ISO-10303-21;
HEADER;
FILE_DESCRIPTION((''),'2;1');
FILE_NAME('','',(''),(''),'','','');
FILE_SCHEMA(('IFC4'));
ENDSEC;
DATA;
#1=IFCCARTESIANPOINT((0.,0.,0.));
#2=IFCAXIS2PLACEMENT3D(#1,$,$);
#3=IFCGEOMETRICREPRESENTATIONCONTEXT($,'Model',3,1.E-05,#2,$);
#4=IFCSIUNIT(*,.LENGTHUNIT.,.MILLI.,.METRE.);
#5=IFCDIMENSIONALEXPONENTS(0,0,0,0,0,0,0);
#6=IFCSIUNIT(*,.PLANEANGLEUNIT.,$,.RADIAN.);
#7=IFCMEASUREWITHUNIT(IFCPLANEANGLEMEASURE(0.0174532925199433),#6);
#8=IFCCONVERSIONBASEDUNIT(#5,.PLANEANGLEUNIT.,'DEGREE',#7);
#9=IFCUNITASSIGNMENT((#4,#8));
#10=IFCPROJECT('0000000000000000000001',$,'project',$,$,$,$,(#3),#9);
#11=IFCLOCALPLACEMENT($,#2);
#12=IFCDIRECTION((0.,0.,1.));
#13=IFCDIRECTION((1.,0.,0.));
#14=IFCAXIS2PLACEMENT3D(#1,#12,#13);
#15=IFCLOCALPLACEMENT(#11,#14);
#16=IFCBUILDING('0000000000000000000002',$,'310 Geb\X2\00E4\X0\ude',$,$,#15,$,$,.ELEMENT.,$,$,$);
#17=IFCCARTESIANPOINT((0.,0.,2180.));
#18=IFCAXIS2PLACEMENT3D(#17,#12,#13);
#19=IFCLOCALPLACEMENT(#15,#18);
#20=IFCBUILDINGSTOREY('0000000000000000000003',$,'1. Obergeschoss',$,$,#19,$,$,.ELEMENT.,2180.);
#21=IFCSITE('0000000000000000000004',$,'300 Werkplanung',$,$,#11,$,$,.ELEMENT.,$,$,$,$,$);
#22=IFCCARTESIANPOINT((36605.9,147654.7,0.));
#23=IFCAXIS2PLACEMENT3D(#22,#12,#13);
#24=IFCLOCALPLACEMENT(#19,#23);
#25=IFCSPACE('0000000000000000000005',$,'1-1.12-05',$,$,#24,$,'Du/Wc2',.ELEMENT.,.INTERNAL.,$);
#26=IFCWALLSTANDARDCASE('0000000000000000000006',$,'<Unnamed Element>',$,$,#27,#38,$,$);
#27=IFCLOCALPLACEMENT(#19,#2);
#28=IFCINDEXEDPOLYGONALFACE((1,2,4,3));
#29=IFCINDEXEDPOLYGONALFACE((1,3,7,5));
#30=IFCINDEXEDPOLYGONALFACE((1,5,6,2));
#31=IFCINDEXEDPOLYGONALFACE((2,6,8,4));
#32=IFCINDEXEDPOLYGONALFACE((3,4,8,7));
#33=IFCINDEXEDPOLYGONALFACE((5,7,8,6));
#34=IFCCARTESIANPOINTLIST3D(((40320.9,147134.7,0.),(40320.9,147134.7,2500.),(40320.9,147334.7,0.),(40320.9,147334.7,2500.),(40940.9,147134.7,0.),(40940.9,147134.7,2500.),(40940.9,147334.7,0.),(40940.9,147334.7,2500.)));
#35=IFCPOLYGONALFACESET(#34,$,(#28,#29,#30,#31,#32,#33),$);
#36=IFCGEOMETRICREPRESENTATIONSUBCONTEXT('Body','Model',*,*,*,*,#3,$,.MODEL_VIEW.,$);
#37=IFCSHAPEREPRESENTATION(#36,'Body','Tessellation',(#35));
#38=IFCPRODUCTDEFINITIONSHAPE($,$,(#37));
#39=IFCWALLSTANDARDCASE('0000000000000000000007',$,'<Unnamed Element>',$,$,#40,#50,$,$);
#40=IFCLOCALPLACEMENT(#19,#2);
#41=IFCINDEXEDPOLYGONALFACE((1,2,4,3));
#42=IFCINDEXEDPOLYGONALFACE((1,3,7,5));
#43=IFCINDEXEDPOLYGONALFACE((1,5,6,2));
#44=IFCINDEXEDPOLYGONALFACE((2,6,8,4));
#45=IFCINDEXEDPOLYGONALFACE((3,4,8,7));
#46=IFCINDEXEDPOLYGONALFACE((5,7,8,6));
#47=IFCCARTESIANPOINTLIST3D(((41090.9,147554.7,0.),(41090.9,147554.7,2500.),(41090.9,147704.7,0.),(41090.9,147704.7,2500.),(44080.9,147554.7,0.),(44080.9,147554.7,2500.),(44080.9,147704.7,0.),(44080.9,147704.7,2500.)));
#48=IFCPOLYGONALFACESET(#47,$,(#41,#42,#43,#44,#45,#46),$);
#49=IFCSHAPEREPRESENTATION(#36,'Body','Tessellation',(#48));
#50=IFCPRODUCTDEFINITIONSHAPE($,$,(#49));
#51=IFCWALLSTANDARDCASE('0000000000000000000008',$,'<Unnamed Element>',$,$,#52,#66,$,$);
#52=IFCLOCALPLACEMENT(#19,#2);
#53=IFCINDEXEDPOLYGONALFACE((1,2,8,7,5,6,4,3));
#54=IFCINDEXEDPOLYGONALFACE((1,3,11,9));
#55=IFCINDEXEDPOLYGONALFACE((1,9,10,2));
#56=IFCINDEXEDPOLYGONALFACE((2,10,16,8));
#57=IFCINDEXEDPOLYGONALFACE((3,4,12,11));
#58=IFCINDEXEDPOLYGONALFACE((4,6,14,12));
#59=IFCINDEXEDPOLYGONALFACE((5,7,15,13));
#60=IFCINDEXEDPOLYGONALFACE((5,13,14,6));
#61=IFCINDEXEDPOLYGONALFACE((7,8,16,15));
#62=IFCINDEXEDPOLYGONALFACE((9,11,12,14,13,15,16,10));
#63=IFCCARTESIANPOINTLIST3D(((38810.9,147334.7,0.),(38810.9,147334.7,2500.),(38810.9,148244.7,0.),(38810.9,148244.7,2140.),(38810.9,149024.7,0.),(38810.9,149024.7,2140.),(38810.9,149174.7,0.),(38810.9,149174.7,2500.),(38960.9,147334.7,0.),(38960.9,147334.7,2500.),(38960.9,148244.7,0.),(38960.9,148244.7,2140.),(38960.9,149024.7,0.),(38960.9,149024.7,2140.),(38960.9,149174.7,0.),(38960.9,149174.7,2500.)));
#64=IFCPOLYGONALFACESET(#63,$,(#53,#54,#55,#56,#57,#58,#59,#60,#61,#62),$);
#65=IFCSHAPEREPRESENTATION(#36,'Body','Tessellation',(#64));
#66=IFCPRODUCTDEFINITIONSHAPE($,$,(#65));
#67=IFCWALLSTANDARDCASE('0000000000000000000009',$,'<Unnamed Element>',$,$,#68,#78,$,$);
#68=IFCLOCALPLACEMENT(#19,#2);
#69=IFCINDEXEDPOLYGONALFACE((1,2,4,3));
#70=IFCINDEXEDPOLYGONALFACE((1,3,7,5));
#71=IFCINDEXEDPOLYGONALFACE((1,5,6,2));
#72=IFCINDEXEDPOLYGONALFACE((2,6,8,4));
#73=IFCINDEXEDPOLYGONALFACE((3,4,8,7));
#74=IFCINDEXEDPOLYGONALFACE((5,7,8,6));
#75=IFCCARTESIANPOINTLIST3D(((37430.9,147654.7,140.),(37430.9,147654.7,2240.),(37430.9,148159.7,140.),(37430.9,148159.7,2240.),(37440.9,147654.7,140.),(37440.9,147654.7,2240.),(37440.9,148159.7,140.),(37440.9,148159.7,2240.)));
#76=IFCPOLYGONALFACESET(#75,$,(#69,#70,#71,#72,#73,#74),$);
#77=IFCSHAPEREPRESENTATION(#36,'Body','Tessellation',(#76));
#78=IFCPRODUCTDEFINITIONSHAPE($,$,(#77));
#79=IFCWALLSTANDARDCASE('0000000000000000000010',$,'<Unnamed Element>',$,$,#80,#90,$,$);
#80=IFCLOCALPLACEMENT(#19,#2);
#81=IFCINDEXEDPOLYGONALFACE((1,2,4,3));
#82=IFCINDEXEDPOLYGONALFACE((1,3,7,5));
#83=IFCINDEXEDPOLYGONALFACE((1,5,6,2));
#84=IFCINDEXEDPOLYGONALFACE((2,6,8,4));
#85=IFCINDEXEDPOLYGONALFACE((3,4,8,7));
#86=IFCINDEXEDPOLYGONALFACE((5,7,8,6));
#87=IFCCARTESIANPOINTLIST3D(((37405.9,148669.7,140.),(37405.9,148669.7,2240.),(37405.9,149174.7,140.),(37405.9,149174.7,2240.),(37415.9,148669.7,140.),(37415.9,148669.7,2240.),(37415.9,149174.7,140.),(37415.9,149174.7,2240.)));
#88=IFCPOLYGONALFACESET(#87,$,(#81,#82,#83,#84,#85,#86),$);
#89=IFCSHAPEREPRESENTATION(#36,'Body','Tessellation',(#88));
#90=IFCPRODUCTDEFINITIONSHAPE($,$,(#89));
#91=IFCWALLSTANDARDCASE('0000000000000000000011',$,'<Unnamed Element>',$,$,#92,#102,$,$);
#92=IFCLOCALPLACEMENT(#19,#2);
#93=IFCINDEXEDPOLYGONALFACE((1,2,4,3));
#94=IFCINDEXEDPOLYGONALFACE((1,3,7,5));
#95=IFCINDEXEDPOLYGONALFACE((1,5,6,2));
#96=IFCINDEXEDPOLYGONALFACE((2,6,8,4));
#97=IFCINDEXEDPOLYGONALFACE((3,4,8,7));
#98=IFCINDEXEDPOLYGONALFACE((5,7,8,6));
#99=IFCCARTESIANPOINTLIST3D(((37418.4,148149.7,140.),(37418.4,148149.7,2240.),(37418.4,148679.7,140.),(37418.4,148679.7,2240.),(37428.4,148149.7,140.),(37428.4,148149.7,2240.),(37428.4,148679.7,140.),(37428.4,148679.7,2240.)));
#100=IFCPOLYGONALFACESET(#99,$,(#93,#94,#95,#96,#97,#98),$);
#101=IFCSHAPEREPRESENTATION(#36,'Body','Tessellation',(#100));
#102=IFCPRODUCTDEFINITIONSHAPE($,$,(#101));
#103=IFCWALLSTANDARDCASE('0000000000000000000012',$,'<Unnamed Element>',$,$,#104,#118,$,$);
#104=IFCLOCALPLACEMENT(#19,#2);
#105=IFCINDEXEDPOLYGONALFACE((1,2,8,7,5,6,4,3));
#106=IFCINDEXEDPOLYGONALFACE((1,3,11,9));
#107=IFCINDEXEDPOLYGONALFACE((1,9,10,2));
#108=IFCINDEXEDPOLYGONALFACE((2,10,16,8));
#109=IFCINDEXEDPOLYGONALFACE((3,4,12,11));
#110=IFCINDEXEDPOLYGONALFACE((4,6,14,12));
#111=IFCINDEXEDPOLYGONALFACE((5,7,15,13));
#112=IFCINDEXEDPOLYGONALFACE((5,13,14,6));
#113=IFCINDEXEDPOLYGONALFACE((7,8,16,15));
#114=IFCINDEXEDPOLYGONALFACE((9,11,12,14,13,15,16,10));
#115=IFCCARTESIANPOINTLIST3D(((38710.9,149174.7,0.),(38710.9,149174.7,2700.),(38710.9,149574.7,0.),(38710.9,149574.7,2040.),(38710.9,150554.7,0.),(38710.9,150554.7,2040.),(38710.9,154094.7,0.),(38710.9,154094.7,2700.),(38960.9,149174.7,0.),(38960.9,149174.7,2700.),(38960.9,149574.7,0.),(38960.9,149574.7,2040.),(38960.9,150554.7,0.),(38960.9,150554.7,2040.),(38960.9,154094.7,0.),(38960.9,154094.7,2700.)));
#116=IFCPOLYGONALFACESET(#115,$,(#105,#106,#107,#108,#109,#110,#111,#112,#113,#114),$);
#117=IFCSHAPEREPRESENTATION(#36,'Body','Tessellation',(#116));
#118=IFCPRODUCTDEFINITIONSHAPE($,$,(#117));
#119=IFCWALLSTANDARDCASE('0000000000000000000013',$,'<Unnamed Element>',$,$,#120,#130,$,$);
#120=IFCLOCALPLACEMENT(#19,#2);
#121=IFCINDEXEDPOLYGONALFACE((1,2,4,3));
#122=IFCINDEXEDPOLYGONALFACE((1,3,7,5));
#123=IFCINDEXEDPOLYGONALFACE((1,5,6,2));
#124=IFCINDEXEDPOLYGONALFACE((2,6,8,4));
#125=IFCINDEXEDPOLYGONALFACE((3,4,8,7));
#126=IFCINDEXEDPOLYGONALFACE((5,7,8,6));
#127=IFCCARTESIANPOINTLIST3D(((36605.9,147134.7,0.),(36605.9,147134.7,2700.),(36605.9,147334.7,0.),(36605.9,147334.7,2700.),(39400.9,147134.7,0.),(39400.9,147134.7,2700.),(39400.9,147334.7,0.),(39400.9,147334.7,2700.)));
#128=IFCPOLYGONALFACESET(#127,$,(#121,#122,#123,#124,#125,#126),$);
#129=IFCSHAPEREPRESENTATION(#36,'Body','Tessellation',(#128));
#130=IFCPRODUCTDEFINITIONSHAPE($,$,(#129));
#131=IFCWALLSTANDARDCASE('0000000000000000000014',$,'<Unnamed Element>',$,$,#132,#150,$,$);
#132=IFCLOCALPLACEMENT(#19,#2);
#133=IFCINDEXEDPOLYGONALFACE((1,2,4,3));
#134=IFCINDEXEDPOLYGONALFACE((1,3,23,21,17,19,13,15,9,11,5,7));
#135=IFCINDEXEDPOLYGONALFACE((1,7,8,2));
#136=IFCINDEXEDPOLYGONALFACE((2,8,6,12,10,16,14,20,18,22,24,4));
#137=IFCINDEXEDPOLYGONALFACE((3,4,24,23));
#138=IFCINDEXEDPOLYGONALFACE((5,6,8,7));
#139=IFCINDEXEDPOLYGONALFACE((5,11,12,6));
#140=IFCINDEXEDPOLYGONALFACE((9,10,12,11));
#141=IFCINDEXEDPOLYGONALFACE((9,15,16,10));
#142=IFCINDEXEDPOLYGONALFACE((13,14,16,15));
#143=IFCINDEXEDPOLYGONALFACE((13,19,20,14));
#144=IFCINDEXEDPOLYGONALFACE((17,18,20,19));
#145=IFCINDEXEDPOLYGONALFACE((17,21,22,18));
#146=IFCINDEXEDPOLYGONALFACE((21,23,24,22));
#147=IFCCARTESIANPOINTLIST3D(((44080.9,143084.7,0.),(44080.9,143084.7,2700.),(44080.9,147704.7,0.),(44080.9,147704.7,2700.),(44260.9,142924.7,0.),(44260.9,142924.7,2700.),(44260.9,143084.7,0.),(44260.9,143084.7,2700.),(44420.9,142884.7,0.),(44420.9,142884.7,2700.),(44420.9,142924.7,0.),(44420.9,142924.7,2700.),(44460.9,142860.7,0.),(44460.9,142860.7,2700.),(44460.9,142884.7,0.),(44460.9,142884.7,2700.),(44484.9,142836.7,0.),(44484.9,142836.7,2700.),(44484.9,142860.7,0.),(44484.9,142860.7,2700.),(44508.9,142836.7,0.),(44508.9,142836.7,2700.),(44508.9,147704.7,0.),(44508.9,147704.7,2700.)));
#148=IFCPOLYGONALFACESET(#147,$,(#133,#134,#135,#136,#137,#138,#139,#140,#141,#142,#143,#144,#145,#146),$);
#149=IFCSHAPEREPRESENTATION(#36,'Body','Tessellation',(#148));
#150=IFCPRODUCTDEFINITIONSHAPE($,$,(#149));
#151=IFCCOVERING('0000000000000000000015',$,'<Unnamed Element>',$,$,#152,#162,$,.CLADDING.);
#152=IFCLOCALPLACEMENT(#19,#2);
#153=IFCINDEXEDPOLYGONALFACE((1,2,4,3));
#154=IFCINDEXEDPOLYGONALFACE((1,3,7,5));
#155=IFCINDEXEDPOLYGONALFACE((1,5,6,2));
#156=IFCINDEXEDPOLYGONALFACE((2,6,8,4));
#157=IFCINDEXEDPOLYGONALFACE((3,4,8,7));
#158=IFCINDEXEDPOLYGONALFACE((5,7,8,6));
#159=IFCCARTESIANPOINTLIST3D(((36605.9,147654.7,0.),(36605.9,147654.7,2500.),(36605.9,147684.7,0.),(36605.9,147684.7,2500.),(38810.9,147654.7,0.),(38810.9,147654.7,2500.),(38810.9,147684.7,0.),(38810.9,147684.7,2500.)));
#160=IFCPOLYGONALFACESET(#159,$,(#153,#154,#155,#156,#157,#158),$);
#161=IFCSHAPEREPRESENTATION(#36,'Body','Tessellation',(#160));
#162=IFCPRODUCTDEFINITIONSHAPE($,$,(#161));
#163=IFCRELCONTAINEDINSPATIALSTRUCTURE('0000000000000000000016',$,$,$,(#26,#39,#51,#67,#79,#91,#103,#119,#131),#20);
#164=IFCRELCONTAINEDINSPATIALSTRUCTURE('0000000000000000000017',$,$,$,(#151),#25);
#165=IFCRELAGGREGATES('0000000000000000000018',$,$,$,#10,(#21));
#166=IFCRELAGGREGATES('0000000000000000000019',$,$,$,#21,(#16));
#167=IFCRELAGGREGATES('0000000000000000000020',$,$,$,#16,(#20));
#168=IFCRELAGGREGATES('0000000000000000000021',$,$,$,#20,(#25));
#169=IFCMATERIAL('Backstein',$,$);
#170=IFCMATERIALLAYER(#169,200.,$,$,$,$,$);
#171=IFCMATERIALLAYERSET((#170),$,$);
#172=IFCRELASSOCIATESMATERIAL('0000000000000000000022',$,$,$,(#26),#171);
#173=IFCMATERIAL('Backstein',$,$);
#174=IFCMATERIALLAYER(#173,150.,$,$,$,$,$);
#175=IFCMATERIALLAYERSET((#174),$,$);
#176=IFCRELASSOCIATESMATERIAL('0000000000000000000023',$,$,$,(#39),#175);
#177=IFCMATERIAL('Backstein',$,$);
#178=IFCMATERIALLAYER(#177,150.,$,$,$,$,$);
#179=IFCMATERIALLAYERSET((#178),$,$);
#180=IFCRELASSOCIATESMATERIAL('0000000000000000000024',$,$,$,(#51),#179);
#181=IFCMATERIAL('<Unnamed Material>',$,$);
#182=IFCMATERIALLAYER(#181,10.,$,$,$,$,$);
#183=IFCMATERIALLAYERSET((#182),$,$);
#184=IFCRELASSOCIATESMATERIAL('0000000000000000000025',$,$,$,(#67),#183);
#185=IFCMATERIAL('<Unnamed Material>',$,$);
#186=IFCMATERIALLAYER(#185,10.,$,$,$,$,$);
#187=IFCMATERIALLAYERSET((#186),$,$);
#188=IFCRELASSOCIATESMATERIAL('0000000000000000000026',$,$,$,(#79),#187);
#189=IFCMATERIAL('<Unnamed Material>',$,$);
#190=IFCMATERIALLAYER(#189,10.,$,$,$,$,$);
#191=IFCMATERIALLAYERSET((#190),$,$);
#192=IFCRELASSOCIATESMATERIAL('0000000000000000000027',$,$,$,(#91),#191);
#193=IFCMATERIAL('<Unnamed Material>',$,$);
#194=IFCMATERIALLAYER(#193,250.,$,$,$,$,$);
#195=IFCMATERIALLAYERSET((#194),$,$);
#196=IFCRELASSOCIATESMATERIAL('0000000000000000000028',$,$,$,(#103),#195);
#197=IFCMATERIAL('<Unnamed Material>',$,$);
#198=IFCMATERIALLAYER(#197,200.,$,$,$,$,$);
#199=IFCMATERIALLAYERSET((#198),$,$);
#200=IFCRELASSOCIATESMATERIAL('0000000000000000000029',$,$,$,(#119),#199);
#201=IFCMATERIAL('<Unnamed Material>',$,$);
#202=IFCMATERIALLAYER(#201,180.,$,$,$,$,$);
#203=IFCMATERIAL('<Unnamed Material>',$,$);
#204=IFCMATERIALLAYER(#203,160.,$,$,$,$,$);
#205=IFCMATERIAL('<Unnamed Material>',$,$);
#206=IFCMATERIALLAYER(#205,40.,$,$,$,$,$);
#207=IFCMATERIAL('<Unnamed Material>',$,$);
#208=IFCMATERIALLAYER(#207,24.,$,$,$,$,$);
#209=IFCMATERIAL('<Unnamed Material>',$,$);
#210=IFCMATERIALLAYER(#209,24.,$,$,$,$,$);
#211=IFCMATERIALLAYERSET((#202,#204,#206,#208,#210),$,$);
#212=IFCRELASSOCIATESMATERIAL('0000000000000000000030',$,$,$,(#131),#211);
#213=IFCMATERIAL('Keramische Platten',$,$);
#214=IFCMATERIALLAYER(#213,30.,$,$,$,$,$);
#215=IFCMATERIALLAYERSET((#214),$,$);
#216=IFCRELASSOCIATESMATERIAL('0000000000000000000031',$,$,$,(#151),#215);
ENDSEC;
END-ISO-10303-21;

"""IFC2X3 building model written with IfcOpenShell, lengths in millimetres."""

from ifc_helpers import new_model, entity, si_unit, converted_unit, frame, frame_2d, origin, origin_with_axes, place, context, subcontext, project, spatial, polyline, rectangle, outline, extrude, material, layer, layer_set, layer_usage, element, save


model = new_model("IFC2X3")

# Units and contexts
model_context = context("Model", 3, precision=1e-05, world=origin())
body_context = subcontext(model_context, "Body", "Model", "MODEL_VIEW")
ifc_project = project(units=[si_unit("LENGTHUNIT", "METRE", prefix="MILLI"), converted_unit("PLANEANGLEUNIT", "DEGREE", entity("IfcPlaneAngleMeasure", 0.0174532925199433), si_unit("PLANEANGLEUNIT", "RADIAN"), dimensions=[0, 0, 0, 0, 0, 0, 0])], contexts=[model_context])

# Site, building, storey
site_placement = place(None, origin())
site = spatial("IfcSite", under=ifc_project, at=site_placement, Name="300 Werkplanung", CompositionType="ELEMENT")
building_placement = place(site_placement, origin_with_axes())
building = spatial("IfcBuilding", under=site, at=building_placement, Name="310 Gebäude", CompositionType="ELEMENT")
storey_placement = place(building_placement, frame((0.0, 0.0, 2180.0), z_axis=(0.0, 0.0, 1.0), x_axis=(1.0, 0.0, 0.0)))
storey = spatial("IfcBuildingStorey", under=building, at=storey_placement, Name="1. Obergeschoss", CompositionType="ELEMENT", Elevation=2180.0)

# Walls
ifc_material_1 = material(Name="Backstein")
ifc_layer_1 = layer(ifc_material_1, 200.0)
ifc_layer_set_1 = layer_set([ifc_layer_1])
ifc_layer_usage_1 = layer_usage(ifc_layer_set_1, "AXIS2", "POSITIVE", 0.0)
wall_1_placement = place(storey_placement, frame((40320.9, 147134.7, 0.0), z_axis=(0.0, 0.0, 1.0), x_axis=(1.0, 0.0, 0.0)))
element("IfcWallStandardCase", 1, at=wall_1_placement, inside=storey, material=ifc_layer_usage_1, Name="<Unnamed Element>", context=body_context, shape_type="SweptSolid", body=[
    extrude(rectangle(XDim=620.0, YDim=200.0, at=frame_2d((310.0, 100.0), x_axis=(1.0, 0.0))), origin_with_axes(), (0.0, 0.0, 1.0), 2500.0),
])
ifc_material_2 = material(Name="Backstein")
ifc_layer_2 = layer(ifc_material_2, 150.0)
ifc_layer_set_2 = layer_set([ifc_layer_2])
ifc_layer_usage_2 = layer_usage(ifc_layer_set_2, "AXIS2", "POSITIVE", 0.0)
wall_2_placement = place(storey_placement, frame((41090.9, 147554.7, 0.0), z_axis=(0.0, 0.0, 1.0), x_axis=(1.0, 0.0, 0.0)))
element("IfcWallStandardCase", 2, at=wall_2_placement, inside=storey, material=ifc_layer_usage_2, Name="<Unnamed Element>", context=body_context, shape_type="SweptSolid", body=[
    extrude(rectangle(XDim=2990.0, YDim=150.0, at=frame_2d((1495.0, 75.0), x_axis=(1.0, 0.0))), origin_with_axes(), (0.0, 0.0, 1.0), 2500.0),
])

# Wall, opening
ifc_material_3 = material(Name="Backstein")
ifc_layer_3 = layer(ifc_material_3, 150.0)
ifc_layer_set_3 = layer_set([ifc_layer_3])
ifc_layer_usage_3 = layer_usage(ifc_layer_set_3, "AXIS2", "POSITIVE", 0.0)
wall_3_placement = place(storey_placement, frame((38960.9, 147334.7, 0.0), z_axis=(0.0, 0.0, 1.0), x_axis=(0.0, 1.0, 0.0)))
wall_3 = element("IfcWallStandardCase", 3, at=wall_3_placement, inside=storey, material=ifc_layer_usage_3, Name="<Unnamed Element>", context=body_context, shape_type="SweptSolid", body=[
    extrude(rectangle(XDim=1840.0, YDim=150.0, at=frame_2d((920.0, 75.0), x_axis=(1.0, 0.0))), origin_with_axes(), (0.0, 0.0, 1.0), 2500.0),
])
opening_1_placement = place(wall_3_placement, frame((910.0, 0.0, 0.0), z_axis=(0.0, 1.0, 0.0), x_axis=(0.0, 0.0, 1.0)))
element("IfcOpeningElement", 4, at=opening_1_placement, cuts=wall_3, ObjectType="Opening", context=body_context, shape_type="SweptSolid", body=[
    extrude(rectangle(XDim=2140.0, YDim=780.0, at=frame_2d((1070.0, 390.0), x_axis=(1.0, 0.0))), origin_with_axes(), (0.0, 0.0, 1.0), 150.0),
])

# Walls
ifc_material_4 = material(Name="<Unnamed Material>")
ifc_layer_4 = layer(ifc_material_4, 10.0)
ifc_layer_set_4 = layer_set([ifc_layer_4])
ifc_layer_usage_4 = layer_usage(ifc_layer_set_4, "AXIS2", "POSITIVE", 0.0)
wall_4_placement = place(storey_placement, frame((37430.9, 148159.7, 140.0), z_axis=(0.0, 0.0, 1.0), x_axis=(0.0, -1.0, 0.0)))
element("IfcWallStandardCase", 5, at=wall_4_placement, inside=storey, material=ifc_layer_usage_4, Name="<Unnamed Element>", context=body_context, shape_type="SweptSolid", body=[
    extrude(rectangle(XDim=505.0, YDim=10.0, at=frame_2d((252.5, 5.0), x_axis=(1.0, 0.0))), origin_with_axes(), (0.0, 0.0, 1.0), 2100.0),
])
ifc_material_5 = material(Name="<Unnamed Material>")
ifc_layer_5 = layer(ifc_material_5, 10.0)
ifc_layer_set_5 = layer_set([ifc_layer_5])
ifc_layer_usage_5 = layer_usage(ifc_layer_set_5, "AXIS2", "POSITIVE", 0.0)
wall_5_placement = place(storey_placement, frame((37405.9, 149174.7, 140.0), z_axis=(0.0, 0.0, 1.0), x_axis=(0.0, -1.0, 0.0)))
element("IfcWallStandardCase", 6, at=wall_5_placement, inside=storey, material=ifc_layer_usage_5, Name="<Unnamed Element>", context=body_context, shape_type="SweptSolid", body=[
    extrude(rectangle(XDim=505.0, YDim=10.0, at=frame_2d((252.5, 5.0), x_axis=(1.0, 0.0))), origin_with_axes(), (0.0, 0.0, 1.0), 2100.0),
])
ifc_material_6 = material(Name="<Unnamed Material>")
ifc_layer_6 = layer(ifc_material_6, 10.0)
ifc_layer_set_6 = layer_set([ifc_layer_6])
ifc_layer_usage_6 = layer_usage(ifc_layer_set_6, "AXIS2", "POSITIVE", 0.0)
wall_6_placement = place(storey_placement, frame((37418.4, 148679.7, 140.0), z_axis=(0.0, 0.0, 1.0), x_axis=(0.0, -1.0, 0.0)))
element("IfcWallStandardCase", 7, at=wall_6_placement, inside=storey, material=ifc_layer_usage_6, Name="<Unnamed Element>", context=body_context, shape_type="SweptSolid", body=[
    extrude(rectangle(XDim=530.0, YDim=10.0, at=frame_2d((265.0, 5.0), x_axis=(1.0, 0.0))), origin_with_axes(), (0.0, 0.0, 1.0), 2100.0),
])

# Wall, opening
ifc_material_7 = material(Name="<Unnamed Material>")
ifc_layer_7 = layer(ifc_material_7, 250.0)
ifc_layer_set_7 = layer_set([ifc_layer_7])
ifc_layer_usage_7 = layer_usage(ifc_layer_set_7, "AXIS2", "POSITIVE", -250.0)
wall_7_placement = place(storey_placement, frame((38960.9, 149174.7, 0.0), z_axis=(0.0, 0.0, 1.0), x_axis=(0.0, 1.0, 0.0)))
wall_7 = element("IfcWallStandardCase", 8, at=wall_7_placement, inside=storey, material=ifc_layer_usage_7, Name="<Unnamed Element>", context=body_context, shape_type="SweptSolid", body=[
    extrude(rectangle(XDim=4920.0, YDim=250.0, at=frame_2d((2460.0, 125.0), x_axis=(1.0, 0.0))), origin_with_axes(), (0.0, 0.0, 1.0), 2700.0),
])
opening_2_placement = place(wall_7_placement, frame((400.0, 0.0, 0.0), z_axis=(0.0, 1.0, 0.0), x_axis=(0.0, 0.0, 1.0)))
element("IfcOpeningElement", 9, at=opening_2_placement, cuts=wall_7, ObjectType="Opening", context=body_context, shape_type="SweptSolid", body=[
    extrude(rectangle(XDim=2040.0, YDim=980.0, at=frame_2d((1020.0, 490.0), x_axis=(1.0, 0.0))), origin_with_axes(), (0.0, 0.0, 1.0), 250.0),
])

# Walls
ifc_material_8 = material(Name="<Unnamed Material>")
ifc_layer_8 = layer(ifc_material_8, 200.0)
ifc_layer_set_8 = layer_set([ifc_layer_8])
ifc_layer_usage_8 = layer_usage(ifc_layer_set_8, "AXIS2", "POSITIVE", 0.0)
wall_8_placement = place(storey_placement, frame((39400.9, 147334.7, 0.0), z_axis=(0.0, 0.0, 1.0), x_axis=(-1.0, 0.0, 0.0)))
element("IfcWallStandardCase", 10, at=wall_8_placement, inside=storey, material=ifc_layer_usage_8, Name="<Unnamed Element>", context=body_context, shape_type="SweptSolid", body=[
    extrude(rectangle(XDim=2795.0, YDim=200.0, at=frame_2d((1397.5, 100.0), x_axis=(1.0, 0.0))), origin_with_axes(), (0.0, 0.0, 1.0), 2700.0),
])
ifc_material_9 = material(Name="<Unnamed Material>")
ifc_layer_9 = layer(ifc_material_9, 180.0)
ifc_material_10 = material(Name="<Unnamed Material>")
ifc_layer_10 = layer(ifc_material_10, 160.0)
ifc_material_11 = material(Name="<Unnamed Material>")
ifc_layer_11 = layer(ifc_material_11, 40.0)
ifc_material_12 = material(Name="<Unnamed Material>")
ifc_layer_12 = layer(ifc_material_12, 24.0)
ifc_material_13 = material(Name="<Unnamed Material>")
ifc_layer_13 = layer(ifc_material_13, 24.0)
ifc_layer_set_9 = layer_set([ifc_layer_9, ifc_layer_10, ifc_layer_11, ifc_layer_12, ifc_layer_13])
ifc_layer_usage_9 = layer_usage(ifc_layer_set_9, "AXIS2", "POSITIVE", -180.0)
wall_9_placement = place(storey_placement, frame((44080.9, 147704.7, 0.0), z_axis=(0.0, 0.0, 1.0), x_axis=(0.0, -1.0, 0.0)))
element("IfcWallStandardCase", 11, at=wall_9_placement, inside=storey, material=ifc_layer_usage_9, Name="<Unnamed Element>", context=body_context, shape_type="SweptSolid", body=[
    extrude(outline(polyline([(0.0, 0.0), (4620.0, 0.0), (4620.0, 180.0), (4780.0, 180.0), (4780.0, 340.0), (4820.0, 340.0), (4820.0, 380.0), (4844.0, 380.0), (4844.0, 404.0), (4868.0, 404.0), (4868.0, 428.0), (0.0, 428.0), (0.0, 0.0)])), origin_with_axes(), (0.0, 0.0, 1.0), 2700.0),
])

# Shared definitions
space_1_placement = place(storey_placement, frame((36605.9, 147654.7, 0.0), z_axis=(0.0, 0.0, 1.0), x_axis=(1.0, 0.0, 0.0)))
space_1 = spatial("IfcSpace", under=storey, at=space_1_placement, Name="1-1.12-05", LongName="Du/Wc2", CompositionType="ELEMENT", InteriorOrExteriorSpace="INTERNAL")

# Covering
ifc_material_14 = material(Name="Keramische Platten")
ifc_layer_14 = layer(ifc_material_14, 30.0)
ifc_layer_set_10 = layer_set([ifc_layer_14])
ifc_layer_usage_10 = layer_usage(ifc_layer_set_10, "AXIS3", "POSITIVE", 0.0)
covering_1_placement = place(space_1_placement, origin_with_axes())
element("IfcCovering", 12, at=covering_1_placement, inside=space_1, material=ifc_layer_usage_10, Name="<Unnamed Element>", PredefinedType="CLADDING", context=body_context, shape_type="SweptSolid", body=[
    extrude(rectangle(XDim=2500.0, YDim=2205.0, at=frame_2d((-1102.5, 1250.0), x_axis=(0.0, 1.0))), frame((2205.0, 0.0, 2500.0), z_axis=(0.0, 1.0, 0.0), x_axis=(1.0, 0.0, 0.0)), (0.0, 0.0, 1.0), 30.0),
])

save(model, "model.ifc")
